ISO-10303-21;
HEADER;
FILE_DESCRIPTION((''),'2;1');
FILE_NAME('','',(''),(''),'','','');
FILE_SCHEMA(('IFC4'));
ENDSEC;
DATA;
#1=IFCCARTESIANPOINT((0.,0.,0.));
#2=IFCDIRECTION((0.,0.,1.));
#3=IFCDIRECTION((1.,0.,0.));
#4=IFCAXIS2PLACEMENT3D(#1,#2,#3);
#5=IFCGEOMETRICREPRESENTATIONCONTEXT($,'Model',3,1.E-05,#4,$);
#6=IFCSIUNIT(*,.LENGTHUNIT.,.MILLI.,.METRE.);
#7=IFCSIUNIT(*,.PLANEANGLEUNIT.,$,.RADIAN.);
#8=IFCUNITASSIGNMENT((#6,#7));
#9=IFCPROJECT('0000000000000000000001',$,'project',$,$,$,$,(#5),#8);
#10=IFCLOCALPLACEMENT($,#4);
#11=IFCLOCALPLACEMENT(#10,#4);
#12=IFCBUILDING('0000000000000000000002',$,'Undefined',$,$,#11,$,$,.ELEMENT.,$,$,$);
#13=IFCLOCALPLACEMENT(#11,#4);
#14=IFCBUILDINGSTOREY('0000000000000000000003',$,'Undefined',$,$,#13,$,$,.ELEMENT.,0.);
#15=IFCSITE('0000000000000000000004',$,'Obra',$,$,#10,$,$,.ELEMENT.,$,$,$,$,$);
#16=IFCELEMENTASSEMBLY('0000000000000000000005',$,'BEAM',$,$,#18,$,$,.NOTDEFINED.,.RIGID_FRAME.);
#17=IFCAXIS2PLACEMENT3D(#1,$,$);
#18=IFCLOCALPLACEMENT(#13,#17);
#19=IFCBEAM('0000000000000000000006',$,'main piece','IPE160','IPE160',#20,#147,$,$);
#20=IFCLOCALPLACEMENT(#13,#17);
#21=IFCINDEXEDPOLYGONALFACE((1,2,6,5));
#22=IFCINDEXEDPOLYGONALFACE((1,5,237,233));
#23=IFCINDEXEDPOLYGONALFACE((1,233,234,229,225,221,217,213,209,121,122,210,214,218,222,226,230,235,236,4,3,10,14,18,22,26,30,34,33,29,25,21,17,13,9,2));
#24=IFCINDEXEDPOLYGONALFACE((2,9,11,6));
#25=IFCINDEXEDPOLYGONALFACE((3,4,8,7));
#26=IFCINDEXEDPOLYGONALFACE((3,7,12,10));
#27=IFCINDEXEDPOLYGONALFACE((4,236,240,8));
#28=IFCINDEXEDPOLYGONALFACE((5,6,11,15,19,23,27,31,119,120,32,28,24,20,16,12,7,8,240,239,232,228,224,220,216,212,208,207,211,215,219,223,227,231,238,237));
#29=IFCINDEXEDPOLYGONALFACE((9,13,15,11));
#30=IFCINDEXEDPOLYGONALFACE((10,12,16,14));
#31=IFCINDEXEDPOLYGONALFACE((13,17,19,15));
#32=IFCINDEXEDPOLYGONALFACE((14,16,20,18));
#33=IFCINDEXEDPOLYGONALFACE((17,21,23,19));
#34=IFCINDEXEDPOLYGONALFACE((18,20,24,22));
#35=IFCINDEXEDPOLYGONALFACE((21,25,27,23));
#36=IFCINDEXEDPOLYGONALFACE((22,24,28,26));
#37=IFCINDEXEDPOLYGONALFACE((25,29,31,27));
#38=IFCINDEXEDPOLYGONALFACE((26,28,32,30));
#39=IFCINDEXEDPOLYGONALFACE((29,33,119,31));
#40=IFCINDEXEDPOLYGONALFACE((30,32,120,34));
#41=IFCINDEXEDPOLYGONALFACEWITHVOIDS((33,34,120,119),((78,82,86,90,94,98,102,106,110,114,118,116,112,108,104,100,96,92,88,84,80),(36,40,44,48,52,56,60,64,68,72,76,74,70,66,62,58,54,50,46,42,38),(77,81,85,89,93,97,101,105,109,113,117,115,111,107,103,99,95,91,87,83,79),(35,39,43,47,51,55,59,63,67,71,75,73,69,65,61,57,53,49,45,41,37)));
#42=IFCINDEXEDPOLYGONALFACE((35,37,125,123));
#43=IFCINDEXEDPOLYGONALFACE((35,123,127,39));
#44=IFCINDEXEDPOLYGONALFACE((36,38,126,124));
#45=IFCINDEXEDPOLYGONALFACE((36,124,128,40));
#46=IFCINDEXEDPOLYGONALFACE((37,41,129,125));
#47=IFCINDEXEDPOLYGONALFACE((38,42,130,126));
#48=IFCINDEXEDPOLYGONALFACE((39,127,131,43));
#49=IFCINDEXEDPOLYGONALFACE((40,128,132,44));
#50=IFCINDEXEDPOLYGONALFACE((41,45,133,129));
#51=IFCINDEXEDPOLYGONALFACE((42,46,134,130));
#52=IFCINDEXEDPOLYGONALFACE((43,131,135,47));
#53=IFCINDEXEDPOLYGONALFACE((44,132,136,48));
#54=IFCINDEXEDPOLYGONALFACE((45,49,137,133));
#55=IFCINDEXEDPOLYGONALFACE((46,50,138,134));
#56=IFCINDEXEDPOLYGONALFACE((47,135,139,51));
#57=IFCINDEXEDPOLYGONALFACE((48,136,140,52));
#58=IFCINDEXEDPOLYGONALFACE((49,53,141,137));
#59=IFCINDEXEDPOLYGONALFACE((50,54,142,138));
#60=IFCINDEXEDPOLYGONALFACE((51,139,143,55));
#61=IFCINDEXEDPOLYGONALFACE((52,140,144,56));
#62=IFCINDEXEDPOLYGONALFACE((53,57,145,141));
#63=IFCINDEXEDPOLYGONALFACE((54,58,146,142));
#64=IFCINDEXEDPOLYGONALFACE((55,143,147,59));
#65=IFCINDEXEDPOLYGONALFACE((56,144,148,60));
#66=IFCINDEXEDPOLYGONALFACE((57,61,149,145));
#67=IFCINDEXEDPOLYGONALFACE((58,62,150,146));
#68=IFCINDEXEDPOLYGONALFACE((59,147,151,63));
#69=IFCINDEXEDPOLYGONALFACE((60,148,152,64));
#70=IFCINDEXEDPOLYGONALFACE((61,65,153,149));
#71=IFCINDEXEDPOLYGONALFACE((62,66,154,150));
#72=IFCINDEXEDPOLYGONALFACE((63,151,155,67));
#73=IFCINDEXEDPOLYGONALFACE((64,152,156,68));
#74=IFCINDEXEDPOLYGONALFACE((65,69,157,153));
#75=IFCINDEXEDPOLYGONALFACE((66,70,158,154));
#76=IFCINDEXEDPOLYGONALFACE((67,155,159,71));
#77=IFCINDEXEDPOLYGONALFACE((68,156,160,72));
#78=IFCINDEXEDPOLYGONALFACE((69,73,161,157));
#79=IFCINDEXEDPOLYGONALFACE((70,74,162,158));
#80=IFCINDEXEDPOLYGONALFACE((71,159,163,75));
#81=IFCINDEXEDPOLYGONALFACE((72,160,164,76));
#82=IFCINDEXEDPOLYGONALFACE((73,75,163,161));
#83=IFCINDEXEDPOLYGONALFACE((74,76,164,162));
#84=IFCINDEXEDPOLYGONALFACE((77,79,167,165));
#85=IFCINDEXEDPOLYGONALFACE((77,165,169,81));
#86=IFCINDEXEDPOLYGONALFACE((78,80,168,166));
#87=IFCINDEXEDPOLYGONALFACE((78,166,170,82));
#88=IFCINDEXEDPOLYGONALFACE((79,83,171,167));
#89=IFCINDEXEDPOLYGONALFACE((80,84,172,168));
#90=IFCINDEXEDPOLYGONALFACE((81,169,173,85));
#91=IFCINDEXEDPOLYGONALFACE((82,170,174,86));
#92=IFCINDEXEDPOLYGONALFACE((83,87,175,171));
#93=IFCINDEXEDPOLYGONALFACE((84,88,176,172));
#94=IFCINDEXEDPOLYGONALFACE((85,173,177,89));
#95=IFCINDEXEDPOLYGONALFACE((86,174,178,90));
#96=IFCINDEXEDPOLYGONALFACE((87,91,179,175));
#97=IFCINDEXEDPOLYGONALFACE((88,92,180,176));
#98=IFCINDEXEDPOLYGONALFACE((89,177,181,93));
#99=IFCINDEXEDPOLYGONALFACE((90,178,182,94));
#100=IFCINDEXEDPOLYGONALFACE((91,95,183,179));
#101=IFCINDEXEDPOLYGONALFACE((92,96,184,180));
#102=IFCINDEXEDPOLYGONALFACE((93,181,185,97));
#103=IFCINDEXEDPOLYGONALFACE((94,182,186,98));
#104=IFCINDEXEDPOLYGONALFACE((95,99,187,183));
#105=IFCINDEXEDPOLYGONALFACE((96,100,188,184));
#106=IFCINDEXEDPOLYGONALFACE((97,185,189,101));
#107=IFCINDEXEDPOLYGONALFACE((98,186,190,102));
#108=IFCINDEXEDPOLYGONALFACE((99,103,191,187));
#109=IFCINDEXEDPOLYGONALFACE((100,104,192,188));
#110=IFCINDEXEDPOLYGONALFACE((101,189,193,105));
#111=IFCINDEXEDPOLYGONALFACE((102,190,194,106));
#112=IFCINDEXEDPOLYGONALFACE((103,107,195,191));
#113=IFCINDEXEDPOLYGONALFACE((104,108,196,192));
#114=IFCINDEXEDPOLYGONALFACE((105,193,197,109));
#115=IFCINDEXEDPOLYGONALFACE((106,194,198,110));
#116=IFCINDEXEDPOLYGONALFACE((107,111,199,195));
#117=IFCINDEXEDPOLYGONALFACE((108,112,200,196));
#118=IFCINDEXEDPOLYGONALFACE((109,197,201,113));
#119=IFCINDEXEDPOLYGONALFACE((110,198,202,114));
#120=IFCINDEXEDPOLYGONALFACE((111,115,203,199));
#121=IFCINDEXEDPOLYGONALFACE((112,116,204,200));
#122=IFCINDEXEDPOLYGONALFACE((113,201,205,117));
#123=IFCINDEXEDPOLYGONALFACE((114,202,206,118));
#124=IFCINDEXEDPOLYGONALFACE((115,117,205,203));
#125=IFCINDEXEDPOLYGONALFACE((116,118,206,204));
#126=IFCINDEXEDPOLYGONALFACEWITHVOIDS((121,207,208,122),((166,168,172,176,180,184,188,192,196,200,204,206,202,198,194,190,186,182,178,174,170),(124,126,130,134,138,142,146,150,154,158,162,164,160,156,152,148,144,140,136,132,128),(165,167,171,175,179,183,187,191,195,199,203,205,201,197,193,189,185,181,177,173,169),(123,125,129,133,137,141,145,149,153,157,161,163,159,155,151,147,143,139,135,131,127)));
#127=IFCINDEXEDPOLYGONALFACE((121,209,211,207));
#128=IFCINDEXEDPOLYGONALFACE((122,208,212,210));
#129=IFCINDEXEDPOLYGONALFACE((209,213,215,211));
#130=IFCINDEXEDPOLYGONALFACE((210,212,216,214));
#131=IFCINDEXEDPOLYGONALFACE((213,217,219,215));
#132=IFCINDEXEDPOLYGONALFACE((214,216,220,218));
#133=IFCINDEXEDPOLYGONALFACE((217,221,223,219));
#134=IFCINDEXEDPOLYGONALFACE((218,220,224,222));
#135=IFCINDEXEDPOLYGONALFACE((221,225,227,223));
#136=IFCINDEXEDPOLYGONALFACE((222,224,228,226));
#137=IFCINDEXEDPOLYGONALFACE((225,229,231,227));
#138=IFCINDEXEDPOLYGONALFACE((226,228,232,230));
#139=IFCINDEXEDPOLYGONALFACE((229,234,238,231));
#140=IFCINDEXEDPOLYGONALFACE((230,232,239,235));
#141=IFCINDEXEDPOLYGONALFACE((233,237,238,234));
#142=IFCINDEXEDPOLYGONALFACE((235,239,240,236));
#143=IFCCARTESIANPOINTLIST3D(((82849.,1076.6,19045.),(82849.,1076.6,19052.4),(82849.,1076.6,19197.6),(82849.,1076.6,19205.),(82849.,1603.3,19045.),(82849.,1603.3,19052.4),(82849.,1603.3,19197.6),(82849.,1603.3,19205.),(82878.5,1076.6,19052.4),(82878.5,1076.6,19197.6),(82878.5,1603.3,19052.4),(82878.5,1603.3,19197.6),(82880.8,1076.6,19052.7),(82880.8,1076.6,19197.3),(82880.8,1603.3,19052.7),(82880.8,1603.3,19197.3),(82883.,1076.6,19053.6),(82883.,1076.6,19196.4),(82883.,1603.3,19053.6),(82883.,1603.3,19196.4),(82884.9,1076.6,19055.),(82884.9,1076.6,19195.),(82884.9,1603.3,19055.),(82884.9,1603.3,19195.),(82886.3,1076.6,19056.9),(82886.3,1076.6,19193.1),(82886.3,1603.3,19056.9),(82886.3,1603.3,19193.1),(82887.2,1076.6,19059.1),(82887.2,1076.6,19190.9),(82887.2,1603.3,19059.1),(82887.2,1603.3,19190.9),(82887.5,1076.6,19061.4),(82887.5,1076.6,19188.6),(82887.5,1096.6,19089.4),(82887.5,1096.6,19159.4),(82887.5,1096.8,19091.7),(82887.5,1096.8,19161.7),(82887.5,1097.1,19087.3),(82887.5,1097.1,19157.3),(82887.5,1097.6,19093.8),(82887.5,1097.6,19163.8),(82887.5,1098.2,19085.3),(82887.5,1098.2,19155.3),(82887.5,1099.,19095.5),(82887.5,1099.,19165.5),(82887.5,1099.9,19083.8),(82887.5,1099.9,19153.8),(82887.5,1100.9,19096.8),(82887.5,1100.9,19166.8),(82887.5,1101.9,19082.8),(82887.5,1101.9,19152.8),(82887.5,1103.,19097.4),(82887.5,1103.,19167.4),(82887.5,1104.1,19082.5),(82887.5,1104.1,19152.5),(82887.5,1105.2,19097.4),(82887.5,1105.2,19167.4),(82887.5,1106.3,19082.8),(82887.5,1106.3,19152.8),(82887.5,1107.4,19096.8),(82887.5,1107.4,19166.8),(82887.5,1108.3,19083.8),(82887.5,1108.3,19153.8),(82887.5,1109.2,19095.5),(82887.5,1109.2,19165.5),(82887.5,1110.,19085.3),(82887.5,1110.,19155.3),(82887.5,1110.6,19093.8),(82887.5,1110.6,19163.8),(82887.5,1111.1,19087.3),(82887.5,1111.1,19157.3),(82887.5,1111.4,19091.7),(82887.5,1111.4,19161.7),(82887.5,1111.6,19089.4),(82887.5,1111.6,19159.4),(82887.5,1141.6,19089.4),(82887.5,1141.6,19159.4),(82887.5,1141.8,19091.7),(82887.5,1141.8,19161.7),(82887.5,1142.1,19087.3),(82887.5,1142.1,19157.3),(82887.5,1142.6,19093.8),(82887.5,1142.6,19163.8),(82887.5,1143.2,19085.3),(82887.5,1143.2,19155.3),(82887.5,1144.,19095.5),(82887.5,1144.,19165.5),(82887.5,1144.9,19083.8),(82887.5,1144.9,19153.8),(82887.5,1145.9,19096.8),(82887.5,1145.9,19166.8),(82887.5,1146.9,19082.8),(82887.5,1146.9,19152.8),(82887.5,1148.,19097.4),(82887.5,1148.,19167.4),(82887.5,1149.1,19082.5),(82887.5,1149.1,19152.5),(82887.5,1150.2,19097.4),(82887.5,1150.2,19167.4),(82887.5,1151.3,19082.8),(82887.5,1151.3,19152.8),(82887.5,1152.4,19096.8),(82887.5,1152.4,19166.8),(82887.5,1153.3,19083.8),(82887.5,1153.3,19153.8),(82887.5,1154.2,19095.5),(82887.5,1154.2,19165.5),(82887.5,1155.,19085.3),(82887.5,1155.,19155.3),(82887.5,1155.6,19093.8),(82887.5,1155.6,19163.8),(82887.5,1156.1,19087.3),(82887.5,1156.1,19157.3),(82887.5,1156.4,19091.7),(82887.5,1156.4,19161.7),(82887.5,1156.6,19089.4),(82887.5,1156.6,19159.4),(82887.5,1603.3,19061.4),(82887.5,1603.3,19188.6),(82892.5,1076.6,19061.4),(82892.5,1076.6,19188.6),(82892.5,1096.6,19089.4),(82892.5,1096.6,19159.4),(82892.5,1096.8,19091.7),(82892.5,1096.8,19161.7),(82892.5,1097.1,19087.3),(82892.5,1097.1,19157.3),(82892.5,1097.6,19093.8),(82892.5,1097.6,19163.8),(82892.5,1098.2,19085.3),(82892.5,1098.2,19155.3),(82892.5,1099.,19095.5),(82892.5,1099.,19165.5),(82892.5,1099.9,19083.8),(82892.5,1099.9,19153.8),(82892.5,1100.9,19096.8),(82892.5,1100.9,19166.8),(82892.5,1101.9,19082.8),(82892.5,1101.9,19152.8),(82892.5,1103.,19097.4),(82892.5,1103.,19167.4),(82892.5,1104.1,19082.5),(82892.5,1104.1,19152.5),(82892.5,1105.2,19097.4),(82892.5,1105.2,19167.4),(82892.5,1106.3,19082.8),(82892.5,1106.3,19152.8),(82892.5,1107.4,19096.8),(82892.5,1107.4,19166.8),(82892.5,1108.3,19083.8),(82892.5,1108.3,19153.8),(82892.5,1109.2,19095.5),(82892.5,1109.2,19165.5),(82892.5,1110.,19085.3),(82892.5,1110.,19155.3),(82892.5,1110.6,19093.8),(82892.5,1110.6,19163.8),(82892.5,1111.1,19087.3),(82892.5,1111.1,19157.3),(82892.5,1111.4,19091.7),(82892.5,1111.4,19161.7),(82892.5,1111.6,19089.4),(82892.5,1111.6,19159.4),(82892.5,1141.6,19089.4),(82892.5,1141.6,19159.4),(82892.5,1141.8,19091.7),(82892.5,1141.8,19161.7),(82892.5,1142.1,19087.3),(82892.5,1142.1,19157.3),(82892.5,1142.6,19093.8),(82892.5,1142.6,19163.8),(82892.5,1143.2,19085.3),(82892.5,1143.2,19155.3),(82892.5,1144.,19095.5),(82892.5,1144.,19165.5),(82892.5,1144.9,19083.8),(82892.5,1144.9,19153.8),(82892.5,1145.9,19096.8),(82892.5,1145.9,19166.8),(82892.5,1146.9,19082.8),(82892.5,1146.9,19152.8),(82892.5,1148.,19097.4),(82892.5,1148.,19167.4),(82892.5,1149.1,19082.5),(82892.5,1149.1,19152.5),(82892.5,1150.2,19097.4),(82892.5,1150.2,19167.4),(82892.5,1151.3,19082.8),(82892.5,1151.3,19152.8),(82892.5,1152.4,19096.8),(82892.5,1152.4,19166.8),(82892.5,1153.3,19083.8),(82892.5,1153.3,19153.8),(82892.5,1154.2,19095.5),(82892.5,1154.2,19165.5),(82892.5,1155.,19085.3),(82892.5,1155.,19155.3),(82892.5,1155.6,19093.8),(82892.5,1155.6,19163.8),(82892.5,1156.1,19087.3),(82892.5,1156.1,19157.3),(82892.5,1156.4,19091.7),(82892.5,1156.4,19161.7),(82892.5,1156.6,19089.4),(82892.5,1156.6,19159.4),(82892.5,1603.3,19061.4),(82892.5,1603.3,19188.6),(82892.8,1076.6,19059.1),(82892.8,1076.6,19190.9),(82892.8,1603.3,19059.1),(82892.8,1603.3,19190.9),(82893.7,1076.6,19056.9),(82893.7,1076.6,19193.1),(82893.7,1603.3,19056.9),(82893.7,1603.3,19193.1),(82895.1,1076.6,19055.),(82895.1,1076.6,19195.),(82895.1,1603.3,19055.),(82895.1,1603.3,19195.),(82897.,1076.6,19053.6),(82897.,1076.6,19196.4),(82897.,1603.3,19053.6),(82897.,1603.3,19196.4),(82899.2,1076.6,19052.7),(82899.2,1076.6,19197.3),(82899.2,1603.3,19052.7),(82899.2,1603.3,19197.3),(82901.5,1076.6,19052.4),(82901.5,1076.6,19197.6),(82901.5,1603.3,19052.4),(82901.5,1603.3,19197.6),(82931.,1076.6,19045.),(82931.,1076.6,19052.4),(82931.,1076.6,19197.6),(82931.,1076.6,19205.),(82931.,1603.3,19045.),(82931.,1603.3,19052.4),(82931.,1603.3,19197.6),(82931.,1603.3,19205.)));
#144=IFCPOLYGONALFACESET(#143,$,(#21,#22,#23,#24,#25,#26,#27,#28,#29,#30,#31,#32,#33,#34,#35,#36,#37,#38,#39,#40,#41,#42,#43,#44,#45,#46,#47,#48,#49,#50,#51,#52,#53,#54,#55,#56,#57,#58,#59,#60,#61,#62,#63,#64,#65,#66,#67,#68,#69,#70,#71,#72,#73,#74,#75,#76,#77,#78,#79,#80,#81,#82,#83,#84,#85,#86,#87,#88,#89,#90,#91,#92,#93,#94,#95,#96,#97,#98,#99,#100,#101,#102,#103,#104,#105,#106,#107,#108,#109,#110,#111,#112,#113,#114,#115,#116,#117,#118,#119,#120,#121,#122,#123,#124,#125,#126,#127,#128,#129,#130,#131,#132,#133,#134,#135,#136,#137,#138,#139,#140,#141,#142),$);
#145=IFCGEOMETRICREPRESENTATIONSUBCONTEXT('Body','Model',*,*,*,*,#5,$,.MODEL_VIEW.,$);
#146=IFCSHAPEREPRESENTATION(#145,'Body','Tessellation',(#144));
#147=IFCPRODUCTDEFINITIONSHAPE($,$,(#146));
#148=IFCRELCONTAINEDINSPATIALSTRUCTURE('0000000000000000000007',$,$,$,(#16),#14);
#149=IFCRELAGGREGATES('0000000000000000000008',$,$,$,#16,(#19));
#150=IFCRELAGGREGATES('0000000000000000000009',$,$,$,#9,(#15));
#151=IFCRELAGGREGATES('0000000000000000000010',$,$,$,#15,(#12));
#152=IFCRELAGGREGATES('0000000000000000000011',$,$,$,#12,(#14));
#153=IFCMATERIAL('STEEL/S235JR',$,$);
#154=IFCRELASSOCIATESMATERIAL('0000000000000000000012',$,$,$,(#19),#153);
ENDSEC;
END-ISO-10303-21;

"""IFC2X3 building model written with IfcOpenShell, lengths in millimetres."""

from ifc_helpers import new_model, si_unit, frame, origin_with_axes, origin_2d_with_axis, place, context, subcontext, project, spatial, circle, i_section, extrude, clip, halfspace, source, transform, mapped, material, element, aggregate, save


model = new_model("IFC2X3")

# Units and contexts
model_context = context("Model", 3, precision=1e-05, world=origin_with_axes())
body_context = subcontext(model_context, "Body", "Model", "MODEL_VIEW")
ifc_project = project(units=[si_unit("LENGTHUNIT", "METRE", prefix="MILLI"), si_unit("PLANEANGLEUNIT", "RADIAN")], contexts=[model_context])

# Site, building, storey
site_placement = place(None, origin_with_axes())
site = spatial("IfcSite", under=ifc_project, at=site_placement, Name="Obra", CompositionType="ELEMENT")
building_placement = place(site_placement, origin_with_axes())
building = spatial("IfcBuilding", under=site, at=building_placement, Name="Undefined", CompositionType="ELEMENT")
storey_placement = place(building_placement, origin_with_axes())
storey = spatial("IfcBuildingStorey", under=building, at=storey_placement, Name="Undefined", CompositionType="ELEMENT", Elevation=0.0)

# Element assembly, beam, opening
assembly_1_placement = place(storey_placement, origin_with_axes())
assembly_1 = element("IfcElementAssembly", 1, at=assembly_1_placement, inside=storey, Name="BEAM", AssemblyPlace="NOTDEFINED", PredefinedType="RIGID_FRAME")
ifc_material_1 = material(Name="STEEL/S235JR")
beam_1_placement = place(assembly_1_placement, frame((82890.0, 1086.6, 19125.0), z_axis=(0.0, 0.0, 1.0), x_axis=(0.0, 1.0, 0.0)))
beam_1 = element("IfcBeam", 2, at=beam_1_placement, material=ifc_material_1, Name="main piece", Description="IPE160", ObjectType="IPE160", context=body_context, shape_type="Clipping", body=[
    clip(extrude(i_section(OverallWidth=82.0, OverallDepth=160.0, WebThickness=5.0, FlangeThickness=7.4, FilletRadius=9.0, at=origin_2d_with_axis()), frame((516.7, 0.0, 0.0), z_axis=(-1.0, 0.0, 0.0), x_axis=(0.0, -1.0, 0.0)), (0.0, 0.0, 1.0), 526.7), halfspace(frame((-10.0, 0.0, -180.0), z_axis=(1.0, 0.0, 0.0), x_axis=(0.0, -1.0, 0.0)), True)),
])
shared_shape_1 = source(origin_with_axes(), body_context, "Body", "SweptSolid", [
    extrude(circle(Radius=7.5, at=origin_2d_with_axis()), frame((0.0, -2.6, 0.0), z_axis=(0.0, 1.0, 0.0), x_axis=(1.0, 0.0, 0.0)), (0.0, 0.0, 1.0), 5.2),
])
opening_1_placement = place(assembly_1_placement, frame((82890.0, 1126.6, 19160.0), z_axis=(0.0, 1.0, 0.0), x_axis=(0.0, 0.0, -1.0)))
element("IfcOpeningElement", 3, at=opening_1_placement, cuts=beam_1, ObjectType="Opening", context=body_context, shape_type="MappedRepresentation", body=[
    mapped(shared_shape_1, transform((0.0, 0.0, -22.5))),
    mapped(shared_shape_1, transform((70.0, 0.0, -22.5))),
    mapped(shared_shape_1, transform((0.0, 0.0, 22.5))),
    mapped(shared_shape_1, transform((70.0, 0.0, 22.5))),
])
aggregate(assembly_1, [beam_1])

save(model, "model.ifc")
